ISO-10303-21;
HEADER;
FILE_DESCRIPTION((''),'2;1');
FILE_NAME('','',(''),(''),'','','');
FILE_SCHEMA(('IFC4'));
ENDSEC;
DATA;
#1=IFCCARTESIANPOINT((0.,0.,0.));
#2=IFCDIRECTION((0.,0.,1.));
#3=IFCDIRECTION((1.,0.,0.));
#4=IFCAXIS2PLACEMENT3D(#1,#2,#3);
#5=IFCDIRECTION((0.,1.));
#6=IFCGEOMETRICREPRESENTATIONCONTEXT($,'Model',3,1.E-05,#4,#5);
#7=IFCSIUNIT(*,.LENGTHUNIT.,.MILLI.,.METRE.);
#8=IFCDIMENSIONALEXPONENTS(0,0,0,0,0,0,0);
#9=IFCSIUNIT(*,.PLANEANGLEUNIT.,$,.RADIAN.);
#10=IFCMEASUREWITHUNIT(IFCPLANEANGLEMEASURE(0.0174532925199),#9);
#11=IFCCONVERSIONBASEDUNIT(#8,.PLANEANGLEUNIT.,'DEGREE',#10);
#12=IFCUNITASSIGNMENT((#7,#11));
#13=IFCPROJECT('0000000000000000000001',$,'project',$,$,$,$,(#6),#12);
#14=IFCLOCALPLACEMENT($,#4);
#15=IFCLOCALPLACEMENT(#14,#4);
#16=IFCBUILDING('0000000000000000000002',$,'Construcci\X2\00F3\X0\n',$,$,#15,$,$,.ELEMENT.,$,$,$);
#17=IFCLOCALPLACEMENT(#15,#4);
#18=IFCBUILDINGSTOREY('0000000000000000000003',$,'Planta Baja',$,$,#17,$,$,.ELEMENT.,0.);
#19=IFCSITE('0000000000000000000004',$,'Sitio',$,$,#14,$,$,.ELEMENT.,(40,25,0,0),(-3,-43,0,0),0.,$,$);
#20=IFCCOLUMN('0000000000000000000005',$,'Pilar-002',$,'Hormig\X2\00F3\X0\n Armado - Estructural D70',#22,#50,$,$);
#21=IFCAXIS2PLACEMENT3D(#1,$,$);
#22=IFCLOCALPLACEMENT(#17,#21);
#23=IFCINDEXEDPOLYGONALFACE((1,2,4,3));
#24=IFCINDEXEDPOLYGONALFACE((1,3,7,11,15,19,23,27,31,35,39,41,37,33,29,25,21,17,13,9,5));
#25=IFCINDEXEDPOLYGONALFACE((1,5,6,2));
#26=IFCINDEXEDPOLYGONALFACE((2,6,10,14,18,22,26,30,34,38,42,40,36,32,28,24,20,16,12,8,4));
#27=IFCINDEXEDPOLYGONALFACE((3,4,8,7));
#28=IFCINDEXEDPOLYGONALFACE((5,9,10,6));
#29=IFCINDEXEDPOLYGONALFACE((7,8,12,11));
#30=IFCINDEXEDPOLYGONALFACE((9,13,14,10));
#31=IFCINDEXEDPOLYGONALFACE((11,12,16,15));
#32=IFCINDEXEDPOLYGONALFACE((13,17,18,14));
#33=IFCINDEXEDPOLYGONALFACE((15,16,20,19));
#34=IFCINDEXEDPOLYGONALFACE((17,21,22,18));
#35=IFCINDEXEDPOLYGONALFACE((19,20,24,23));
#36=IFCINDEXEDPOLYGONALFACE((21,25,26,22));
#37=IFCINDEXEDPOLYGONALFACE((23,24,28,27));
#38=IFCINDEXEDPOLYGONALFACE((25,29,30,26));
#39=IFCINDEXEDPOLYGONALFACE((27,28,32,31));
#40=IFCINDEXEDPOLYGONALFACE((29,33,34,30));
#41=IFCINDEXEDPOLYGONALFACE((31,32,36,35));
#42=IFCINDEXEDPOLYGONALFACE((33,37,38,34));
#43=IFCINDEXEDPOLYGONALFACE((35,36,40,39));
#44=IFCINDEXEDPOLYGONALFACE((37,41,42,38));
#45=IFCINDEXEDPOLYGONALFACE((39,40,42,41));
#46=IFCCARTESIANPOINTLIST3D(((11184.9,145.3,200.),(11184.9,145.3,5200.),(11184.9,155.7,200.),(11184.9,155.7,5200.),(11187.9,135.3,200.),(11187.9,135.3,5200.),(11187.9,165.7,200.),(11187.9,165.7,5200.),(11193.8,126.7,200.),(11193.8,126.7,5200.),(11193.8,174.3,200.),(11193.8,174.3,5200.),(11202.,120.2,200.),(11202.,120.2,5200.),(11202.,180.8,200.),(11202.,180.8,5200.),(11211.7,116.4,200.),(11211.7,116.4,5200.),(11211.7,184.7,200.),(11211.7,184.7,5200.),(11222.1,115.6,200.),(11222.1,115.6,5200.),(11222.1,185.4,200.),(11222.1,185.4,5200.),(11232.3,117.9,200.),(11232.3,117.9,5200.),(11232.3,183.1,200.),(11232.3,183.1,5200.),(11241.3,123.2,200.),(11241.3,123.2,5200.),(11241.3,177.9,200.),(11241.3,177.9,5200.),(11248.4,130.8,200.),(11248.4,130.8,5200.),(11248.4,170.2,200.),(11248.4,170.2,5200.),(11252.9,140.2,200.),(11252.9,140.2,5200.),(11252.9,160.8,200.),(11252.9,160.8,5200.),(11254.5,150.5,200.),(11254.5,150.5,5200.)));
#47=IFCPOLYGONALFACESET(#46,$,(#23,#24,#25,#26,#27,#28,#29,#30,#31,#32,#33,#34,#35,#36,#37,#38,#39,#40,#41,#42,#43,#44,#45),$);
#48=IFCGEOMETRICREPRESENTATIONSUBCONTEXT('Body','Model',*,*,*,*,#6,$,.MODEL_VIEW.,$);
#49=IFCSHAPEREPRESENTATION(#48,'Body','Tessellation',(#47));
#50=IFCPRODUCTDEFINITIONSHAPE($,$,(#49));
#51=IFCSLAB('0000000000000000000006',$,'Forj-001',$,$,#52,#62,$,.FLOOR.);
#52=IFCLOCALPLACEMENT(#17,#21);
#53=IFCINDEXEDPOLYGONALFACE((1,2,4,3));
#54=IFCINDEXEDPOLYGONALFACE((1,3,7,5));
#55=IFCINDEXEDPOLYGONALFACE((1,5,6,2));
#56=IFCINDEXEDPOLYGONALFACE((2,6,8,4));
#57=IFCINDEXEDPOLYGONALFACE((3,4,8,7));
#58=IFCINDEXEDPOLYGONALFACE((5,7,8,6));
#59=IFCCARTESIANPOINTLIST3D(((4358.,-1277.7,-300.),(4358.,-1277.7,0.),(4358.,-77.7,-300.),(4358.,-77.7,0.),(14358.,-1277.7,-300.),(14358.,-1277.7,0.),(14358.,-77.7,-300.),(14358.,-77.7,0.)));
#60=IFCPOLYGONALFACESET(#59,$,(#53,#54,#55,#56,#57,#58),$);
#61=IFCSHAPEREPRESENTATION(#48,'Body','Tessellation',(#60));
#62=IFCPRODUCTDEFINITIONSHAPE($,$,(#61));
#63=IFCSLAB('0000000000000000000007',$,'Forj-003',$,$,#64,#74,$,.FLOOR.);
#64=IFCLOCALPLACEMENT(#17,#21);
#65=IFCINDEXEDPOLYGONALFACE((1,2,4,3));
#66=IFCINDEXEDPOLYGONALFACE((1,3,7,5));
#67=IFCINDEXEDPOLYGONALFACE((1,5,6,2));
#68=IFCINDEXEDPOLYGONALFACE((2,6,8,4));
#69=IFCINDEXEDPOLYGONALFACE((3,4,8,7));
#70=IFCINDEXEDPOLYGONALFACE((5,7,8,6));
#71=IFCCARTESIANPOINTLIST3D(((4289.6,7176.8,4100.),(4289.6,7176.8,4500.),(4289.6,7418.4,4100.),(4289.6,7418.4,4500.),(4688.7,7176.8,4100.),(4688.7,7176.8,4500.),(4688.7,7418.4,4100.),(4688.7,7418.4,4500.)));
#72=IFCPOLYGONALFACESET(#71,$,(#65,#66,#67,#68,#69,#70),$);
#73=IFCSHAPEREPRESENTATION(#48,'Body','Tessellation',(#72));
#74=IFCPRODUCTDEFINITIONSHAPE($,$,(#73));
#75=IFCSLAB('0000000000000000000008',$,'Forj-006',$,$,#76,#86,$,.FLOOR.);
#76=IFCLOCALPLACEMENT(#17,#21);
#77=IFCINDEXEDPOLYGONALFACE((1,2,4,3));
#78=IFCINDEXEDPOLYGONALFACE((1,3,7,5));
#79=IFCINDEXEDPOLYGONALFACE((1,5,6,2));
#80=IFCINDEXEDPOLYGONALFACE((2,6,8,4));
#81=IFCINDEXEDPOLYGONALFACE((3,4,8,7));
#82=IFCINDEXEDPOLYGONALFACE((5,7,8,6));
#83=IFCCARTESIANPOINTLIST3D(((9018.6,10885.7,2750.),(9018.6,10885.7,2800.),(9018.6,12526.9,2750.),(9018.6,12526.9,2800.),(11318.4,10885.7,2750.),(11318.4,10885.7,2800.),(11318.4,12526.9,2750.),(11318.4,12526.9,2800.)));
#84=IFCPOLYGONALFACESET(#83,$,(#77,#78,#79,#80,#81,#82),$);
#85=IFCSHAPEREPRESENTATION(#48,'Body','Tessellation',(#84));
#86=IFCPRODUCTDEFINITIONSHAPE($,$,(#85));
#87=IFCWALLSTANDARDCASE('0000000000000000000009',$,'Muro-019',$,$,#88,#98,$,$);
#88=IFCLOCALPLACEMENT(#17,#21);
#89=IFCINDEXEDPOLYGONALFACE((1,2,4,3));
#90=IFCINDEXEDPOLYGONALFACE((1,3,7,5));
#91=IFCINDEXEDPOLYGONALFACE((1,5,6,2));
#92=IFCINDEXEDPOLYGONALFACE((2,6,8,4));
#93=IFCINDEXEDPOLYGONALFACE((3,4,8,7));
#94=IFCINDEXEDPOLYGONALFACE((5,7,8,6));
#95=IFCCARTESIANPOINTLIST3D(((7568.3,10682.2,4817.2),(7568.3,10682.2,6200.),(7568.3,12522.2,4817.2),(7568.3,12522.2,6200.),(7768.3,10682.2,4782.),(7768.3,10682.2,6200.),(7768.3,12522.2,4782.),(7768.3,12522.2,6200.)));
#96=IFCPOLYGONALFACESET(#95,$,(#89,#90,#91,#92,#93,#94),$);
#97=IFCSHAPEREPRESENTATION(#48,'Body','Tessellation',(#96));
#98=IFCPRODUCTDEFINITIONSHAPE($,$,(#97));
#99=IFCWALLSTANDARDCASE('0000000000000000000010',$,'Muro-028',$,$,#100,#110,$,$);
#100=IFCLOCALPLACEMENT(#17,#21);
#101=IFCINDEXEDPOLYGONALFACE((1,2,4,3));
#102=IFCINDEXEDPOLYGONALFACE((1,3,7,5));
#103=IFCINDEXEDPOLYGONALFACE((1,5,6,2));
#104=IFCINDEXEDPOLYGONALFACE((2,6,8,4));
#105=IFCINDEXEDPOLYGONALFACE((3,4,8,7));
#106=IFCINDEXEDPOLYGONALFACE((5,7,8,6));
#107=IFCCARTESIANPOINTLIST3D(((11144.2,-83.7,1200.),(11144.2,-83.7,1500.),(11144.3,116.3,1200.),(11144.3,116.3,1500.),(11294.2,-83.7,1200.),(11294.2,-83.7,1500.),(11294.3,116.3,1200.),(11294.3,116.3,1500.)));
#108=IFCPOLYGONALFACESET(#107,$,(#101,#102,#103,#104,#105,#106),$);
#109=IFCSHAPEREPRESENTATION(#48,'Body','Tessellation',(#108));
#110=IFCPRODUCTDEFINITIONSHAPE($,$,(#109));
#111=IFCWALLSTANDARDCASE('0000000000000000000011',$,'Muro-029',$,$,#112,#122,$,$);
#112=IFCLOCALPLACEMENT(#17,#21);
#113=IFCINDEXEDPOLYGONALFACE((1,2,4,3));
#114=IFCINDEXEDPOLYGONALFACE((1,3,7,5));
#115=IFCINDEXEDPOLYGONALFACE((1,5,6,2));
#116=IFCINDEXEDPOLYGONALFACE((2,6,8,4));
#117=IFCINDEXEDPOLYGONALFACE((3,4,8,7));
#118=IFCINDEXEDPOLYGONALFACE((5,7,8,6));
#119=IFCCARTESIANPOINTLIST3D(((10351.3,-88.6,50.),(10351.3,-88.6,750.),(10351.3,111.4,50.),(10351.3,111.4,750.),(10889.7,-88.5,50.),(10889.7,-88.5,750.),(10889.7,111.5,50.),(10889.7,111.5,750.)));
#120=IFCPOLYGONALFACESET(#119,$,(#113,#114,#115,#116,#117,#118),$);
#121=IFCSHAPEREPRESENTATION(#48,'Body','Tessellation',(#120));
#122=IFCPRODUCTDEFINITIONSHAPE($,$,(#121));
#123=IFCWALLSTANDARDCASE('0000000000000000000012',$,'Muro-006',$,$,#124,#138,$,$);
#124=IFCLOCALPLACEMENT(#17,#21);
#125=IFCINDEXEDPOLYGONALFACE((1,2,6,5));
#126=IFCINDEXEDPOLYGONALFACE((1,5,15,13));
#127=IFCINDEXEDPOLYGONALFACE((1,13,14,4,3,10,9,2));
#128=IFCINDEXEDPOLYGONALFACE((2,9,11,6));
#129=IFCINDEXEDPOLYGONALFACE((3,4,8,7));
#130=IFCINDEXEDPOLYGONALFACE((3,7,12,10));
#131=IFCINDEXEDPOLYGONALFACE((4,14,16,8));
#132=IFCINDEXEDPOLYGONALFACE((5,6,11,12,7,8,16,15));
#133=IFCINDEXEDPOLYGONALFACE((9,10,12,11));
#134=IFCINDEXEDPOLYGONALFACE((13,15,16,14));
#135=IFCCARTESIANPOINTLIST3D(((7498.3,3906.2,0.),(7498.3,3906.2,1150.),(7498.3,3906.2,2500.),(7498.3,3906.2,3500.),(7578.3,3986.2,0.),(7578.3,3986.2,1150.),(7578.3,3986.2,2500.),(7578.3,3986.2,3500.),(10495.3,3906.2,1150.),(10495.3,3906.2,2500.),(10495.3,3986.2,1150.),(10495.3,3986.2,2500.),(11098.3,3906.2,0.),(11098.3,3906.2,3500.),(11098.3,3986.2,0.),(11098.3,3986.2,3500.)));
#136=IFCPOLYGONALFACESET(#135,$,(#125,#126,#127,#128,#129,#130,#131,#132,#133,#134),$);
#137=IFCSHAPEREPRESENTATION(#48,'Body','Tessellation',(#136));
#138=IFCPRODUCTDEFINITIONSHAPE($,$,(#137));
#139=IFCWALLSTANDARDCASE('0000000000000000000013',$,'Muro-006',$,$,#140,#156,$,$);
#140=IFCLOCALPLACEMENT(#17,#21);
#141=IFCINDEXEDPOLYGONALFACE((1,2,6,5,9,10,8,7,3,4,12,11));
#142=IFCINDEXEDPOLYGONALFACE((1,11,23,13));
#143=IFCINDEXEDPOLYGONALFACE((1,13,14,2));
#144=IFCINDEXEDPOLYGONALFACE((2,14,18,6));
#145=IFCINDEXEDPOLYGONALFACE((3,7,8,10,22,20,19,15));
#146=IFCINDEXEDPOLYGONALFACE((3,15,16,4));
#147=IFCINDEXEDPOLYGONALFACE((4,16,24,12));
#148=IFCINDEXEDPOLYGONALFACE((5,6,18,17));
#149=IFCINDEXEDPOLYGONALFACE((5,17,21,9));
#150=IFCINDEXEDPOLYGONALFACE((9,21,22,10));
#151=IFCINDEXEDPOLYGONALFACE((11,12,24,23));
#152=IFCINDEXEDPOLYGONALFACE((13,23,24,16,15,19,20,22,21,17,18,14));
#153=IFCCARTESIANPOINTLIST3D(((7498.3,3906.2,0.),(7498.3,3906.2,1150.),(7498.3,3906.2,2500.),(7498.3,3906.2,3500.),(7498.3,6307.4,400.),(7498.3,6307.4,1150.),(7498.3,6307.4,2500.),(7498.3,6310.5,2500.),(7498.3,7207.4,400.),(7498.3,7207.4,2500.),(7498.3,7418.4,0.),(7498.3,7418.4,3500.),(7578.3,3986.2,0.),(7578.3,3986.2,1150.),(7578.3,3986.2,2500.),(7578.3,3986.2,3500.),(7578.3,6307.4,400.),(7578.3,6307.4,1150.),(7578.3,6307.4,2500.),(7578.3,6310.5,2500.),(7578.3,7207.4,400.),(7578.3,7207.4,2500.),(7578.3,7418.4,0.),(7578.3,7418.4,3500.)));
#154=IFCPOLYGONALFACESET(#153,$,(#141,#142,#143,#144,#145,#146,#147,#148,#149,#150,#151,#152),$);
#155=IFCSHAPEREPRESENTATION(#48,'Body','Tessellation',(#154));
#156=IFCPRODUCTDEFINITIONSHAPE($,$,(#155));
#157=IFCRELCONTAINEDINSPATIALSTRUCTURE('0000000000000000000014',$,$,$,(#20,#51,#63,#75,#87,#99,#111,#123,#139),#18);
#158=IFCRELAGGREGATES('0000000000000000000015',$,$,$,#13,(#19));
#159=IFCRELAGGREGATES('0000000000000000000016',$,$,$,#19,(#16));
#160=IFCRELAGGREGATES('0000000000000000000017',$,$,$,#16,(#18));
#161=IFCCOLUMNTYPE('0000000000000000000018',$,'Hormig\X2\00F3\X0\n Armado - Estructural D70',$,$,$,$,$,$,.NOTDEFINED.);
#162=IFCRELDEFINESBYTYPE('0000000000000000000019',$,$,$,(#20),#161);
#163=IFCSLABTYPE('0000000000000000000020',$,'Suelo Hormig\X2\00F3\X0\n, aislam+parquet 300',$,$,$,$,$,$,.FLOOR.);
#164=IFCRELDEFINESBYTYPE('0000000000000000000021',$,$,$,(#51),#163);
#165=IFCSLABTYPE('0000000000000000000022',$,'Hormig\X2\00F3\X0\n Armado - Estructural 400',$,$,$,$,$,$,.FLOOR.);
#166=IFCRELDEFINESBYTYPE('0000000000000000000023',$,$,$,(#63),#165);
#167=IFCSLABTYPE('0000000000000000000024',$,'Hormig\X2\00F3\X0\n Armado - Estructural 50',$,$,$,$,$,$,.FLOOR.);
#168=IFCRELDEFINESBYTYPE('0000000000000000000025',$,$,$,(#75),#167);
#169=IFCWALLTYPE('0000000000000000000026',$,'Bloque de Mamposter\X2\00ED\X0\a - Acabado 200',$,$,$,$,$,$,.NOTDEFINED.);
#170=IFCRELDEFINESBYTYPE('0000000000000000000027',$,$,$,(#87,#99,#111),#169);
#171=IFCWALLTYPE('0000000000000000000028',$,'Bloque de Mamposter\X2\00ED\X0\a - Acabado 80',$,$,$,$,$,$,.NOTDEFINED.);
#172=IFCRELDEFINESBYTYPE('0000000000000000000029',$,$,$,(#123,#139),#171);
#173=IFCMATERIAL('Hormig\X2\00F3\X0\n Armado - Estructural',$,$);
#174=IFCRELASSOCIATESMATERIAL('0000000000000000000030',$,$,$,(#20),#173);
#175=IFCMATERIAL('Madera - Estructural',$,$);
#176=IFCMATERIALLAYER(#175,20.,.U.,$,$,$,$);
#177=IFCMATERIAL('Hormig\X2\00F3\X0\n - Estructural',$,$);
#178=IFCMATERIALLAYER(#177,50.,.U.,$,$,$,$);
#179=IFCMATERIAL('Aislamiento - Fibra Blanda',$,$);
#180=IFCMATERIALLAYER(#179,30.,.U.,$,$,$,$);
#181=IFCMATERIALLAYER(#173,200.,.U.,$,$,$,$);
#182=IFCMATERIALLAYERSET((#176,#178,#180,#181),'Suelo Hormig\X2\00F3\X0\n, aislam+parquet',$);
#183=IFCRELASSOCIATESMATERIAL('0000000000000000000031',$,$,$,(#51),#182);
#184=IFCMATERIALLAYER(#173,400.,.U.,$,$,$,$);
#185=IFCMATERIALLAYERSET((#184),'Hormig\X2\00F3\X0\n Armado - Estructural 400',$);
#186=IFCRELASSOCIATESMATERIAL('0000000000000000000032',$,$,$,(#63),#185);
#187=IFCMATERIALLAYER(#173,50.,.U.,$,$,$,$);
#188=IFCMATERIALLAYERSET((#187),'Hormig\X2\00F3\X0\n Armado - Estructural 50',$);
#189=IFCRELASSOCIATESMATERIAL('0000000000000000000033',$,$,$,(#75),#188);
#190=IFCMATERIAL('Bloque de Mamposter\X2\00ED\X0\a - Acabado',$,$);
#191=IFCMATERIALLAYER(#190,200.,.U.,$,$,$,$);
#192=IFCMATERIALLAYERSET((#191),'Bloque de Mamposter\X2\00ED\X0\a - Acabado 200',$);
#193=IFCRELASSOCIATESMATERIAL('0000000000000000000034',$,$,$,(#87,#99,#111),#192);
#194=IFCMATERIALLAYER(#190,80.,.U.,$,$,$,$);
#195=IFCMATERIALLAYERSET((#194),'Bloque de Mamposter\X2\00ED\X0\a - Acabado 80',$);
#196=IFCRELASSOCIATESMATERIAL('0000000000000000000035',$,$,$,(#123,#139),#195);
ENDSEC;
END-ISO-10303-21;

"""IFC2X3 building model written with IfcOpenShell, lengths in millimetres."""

from ifc_helpers import new_model, entity, si_unit, converted_unit, direction, frame, origin_with_axes, origin_2d_with_axis, place, context, subcontext, project, spatial, polyline, rectangle, circle, outline, extrude, clip, halfspace, material, layer, layer_set, layer_usage, type_object, element, save


model = new_model("IFC2X3")

# Units and contexts
model_context = context("Model", 3, precision=1e-05, world=origin_with_axes(), true_north=direction((0.0, 1.0)))
body_context = subcontext(model_context, "Body", "Model", "MODEL_VIEW")
ifc_project = project(units=[si_unit("LENGTHUNIT", "METRE", prefix="MILLI"), converted_unit("PLANEANGLEUNIT", "DEGREE", entity("IfcPlaneAngleMeasure", 0.0174532925199), si_unit("PLANEANGLEUNIT", "RADIAN"), dimensions=[0, 0, 0, 0, 0, 0, 0])], contexts=[model_context])

# Site, building, storey
site_placement = place(None, origin_with_axes())
site = spatial("IfcSite", under=ifc_project, at=site_placement, Name="Sitio", CompositionType="ELEMENT", RefLatitude=(40, 25, 0, 0), RefLongitude=(-3, -43, 0, 0), RefElevation=0.0)
building_placement = place(site_placement, origin_with_axes())
building = spatial("IfcBuilding", under=site, at=building_placement, Name="Construcción", CompositionType="ELEMENT")
storey_placement = place(building_placement, origin_with_axes())
storey = spatial("IfcBuildingStorey", under=building, at=storey_placement, Name="Planta Baja", CompositionType="ELEMENT", Elevation=0.0)

# Column
ifc_material_1 = material(Name="Hormigón Armado - Estructural")
column_type_1 = type_object("IfcColumnType", Name="Hormigón Armado - Estructural D70", PredefinedType="NOTDEFINED")
column_placement = place(storey_placement, frame((11219.5, 150.5, 200.0), z_axis=(0.0, 0.0, 1.0), x_axis=(1.0, 0.0, 0.0)))
element("IfcColumn", 1, at=column_placement, inside=storey, type_object=column_type_1, material=ifc_material_1, Name="Pilar-002", ObjectType="Hormigón Armado - Estructural D70", context=body_context, shape_type="SweptSolid", body=[
    extrude(circle(Radius=35.0, at=origin_2d_with_axis()), origin_with_axes(), (0.0, 0.0, 1.0), 5000.0),
])

# Slabs
ifc_material_2 = material(Name="Madera - Estructural")
ifc_layer_1 = layer(ifc_material_2, 20.0, ventilated="UNKNOWN")
ifc_material_3 = material(Name="Hormigón - Estructural")
ifc_layer_2 = layer(ifc_material_3, 50.0, ventilated="UNKNOWN")
ifc_material_4 = material(Name="Aislamiento - Fibra Blanda")
ifc_layer_3 = layer(ifc_material_4, 30.0, ventilated="UNKNOWN")
ifc_layer_4 = layer(ifc_material_1, 200.0, ventilated="UNKNOWN")
ifc_layer_set_1 = layer_set([ifc_layer_1, ifc_layer_2, ifc_layer_3, ifc_layer_4], Name="Suelo Hormigón, aislam+parquet")
ifc_layer_usage_1 = layer_usage(ifc_layer_set_1, "AXIS3", "NEGATIVE", 300.0)
slab_type_1 = type_object("IfcSlabType", Name="Suelo Hormigón, aislam+parquet 300", PredefinedType="FLOOR")
slab_1_placement = place(storey_placement, frame((4358.0, -77.7, 0.0), z_axis=(0.0, 0.0, 1.0), x_axis=(1.0, 0.0, 0.0)))
element("IfcSlab", 2, at=slab_1_placement, inside=storey, type_object=slab_type_1, material=ifc_layer_usage_1, Name="Forj-001", PredefinedType="FLOOR", context=body_context, shape_type="SweptSolid", body=[
    extrude(outline(polyline([(0.0, 0.0), (0.0, -1200.0), (10000.0, -1200.0), (10000.0, 0.0), (0.0, 0.0)])), frame((0.0, 0.0, -300.0), z_axis=(0.0, 0.0, 1.0), x_axis=(1.0, 0.0, 0.0)), (0.0, 0.0, 1.0), 300.0),
])
ifc_layer_5 = layer(ifc_material_1, 400.0, ventilated="UNKNOWN")
ifc_layer_set_2 = layer_set([ifc_layer_5], Name="Hormigón Armado - Estructural 400")
ifc_layer_usage_2 = layer_usage(ifc_layer_set_2, "AXIS3", "NEGATIVE", 400.0)
slab_type_2 = type_object("IfcSlabType", Name="Hormigón Armado - Estructural 400", PredefinedType="FLOOR")
slab_2_placement = place(storey_placement, frame((4289.6, 7176.8, 4500.0), z_axis=(0.0, 0.0, 1.0), x_axis=(1.0, 0.0, 0.0)))
element("IfcSlab", 3, at=slab_2_placement, inside=storey, type_object=slab_type_2, material=ifc_layer_usage_2, Name="Forj-003", PredefinedType="FLOOR", context=body_context, shape_type="SweptSolid", body=[
    extrude(outline(polyline([(0.0, 0.0), (399.0, 0.0), (399.0, 241.6), (0.0, 241.6), (0.0, 0.0)])), frame((0.0, 0.0, -400.0), z_axis=(0.0, 0.0, 1.0), x_axis=(1.0, 0.0, 0.0)), (0.0, 0.0, 1.0), 400.0),
])
ifc_layer_6 = layer(ifc_material_1, 50.0, ventilated="UNKNOWN")
ifc_layer_set_3 = layer_set([ifc_layer_6], Name="Hormigón Armado - Estructural 50")
ifc_layer_usage_3 = layer_usage(ifc_layer_set_3, "AXIS3", "NEGATIVE", 50.0)
slab_type_3 = type_object("IfcSlabType", Name="Hormigón Armado - Estructural 50", PredefinedType="FLOOR")
slab_3_placement = place(storey_placement, frame((9018.6, 10885.7, 2800.0), z_axis=(0.0, 0.0, 1.0), x_axis=(1.0, 0.0, 0.0)))
element("IfcSlab", 4, at=slab_3_placement, inside=storey, type_object=slab_type_3, material=ifc_layer_usage_3, Name="Forj-006", PredefinedType="FLOOR", context=body_context, shape_type="SweptSolid", body=[
    extrude(outline(polyline([(0.0, 0.0), (2299.8, 0.0), (2299.8, 1641.3), (0.0, 1641.2), (0.0, 0.0)])), frame((0.0, 0.0, -50.0), z_axis=(0.0, 0.0, 1.0), x_axis=(1.0, 0.0, 0.0)), (0.0, 0.0, 1.0), 50.0),
])

# Shared definitions
ifc_material_5 = material(Name="Bloque de Mampostería - Acabado")
ifc_layer_7 = layer(ifc_material_5, 200.0, ventilated="UNKNOWN")
ifc_layer_set_4 = layer_set([ifc_layer_7], Name="Bloque de Mampostería - Acabado 200")
wall_type_1 = type_object("IfcWallType", Name="Bloque de Mampostería - Acabado 200", PredefinedType="NOTDEFINED")

# Walls
ifc_layer_usage_4 = layer_usage(ifc_layer_set_4, "AXIS2", "POSITIVE", -200.0)
wall_1_placement = place(storey_placement, frame((7768.3, 12522.2, 3000.0), z_axis=(0.0, 0.0, 1.0), x_axis=(0.0, -1.0, 0.0)))
element("IfcWallStandardCase", 5, at=wall_1_placement, inside=storey, type_object=wall_type_1, material=ifc_layer_usage_4, Name="Muro-019", context=body_context, shape_type="Clipping", body=[
    clip(extrude(outline(polyline([(0.0, -200.0), (1840.0, -200.0), (1840.0, 0.0), (0.0, 0.0), (0.0, -200.0)])), origin_with_axes(), (0.0, 0.0, 1.0), 3200.0), halfspace(frame((0.0, 304.7, 1728.2), z_axis=(0.0, 0.173648, 0.984808), x_axis=(0.0, -0.984808, 0.173648)), True)),
])
ifc_layer_usage_5 = layer_usage(ifc_layer_set_4, "AXIS2", "POSITIVE", 0.0)
wall_2_placement = place(storey_placement, frame((11144.2, -83.7, 1200.0), z_axis=(0.0, 0.0, 1.0), x_axis=(1.0, -0.000082, 0.0)))
element("IfcWallStandardCase", 6, at=wall_2_placement, inside=storey, type_object=wall_type_1, material=ifc_layer_usage_5, Name="Muro-028", context=body_context, shape_type="SweptSolid", body=[
    extrude(outline(polyline([(0.0, 0.0), (150.0, 0.0), (150.0, 200.0), (0.0, 200.0), (0.0, 0.0)])), origin_with_axes(), (0.0, 0.0, 1.0), 300.0),
])
ifc_layer_usage_6 = layer_usage(ifc_layer_set_4, "AXIS2", "POSITIVE", 0.0)
wall_3_placement = place(storey_placement, frame((10351.3, -88.6, 50.0), z_axis=(0.0, 0.0, 1.0), x_axis=(1.0, 0.000068, 0.0)))
element("IfcWallStandardCase", 7, at=wall_3_placement, inside=storey, type_object=wall_type_1, material=ifc_layer_usage_6, Name="Muro-029", context=body_context, shape_type="SweptSolid", body=[
    extrude(outline(polyline([(0.0, 0.0), (538.4, 0.0), (538.4, 200.0), (0.0, 200.0), (0.0, 0.0)])), origin_with_axes(), (0.0, 0.0, 1.0), 700.0),
])

# Wall, opening
ifc_layer_8 = layer(ifc_material_5, 80.0, ventilated="UNKNOWN")
ifc_layer_set_5 = layer_set([ifc_layer_8], Name="Bloque de Mampostería - Acabado 80")
ifc_layer_usage_7 = layer_usage(ifc_layer_set_5, "AXIS2", "POSITIVE", 0.0)
wall_type_2 = type_object("IfcWallType", Name="Bloque de Mampostería - Acabado 80", PredefinedType="NOTDEFINED")
wall_4_placement = place(storey_placement, frame((7578.3, 3906.2, 0.0), z_axis=(0.0, 0.0, 1.0), x_axis=(1.0, 0.0, 0.0)))
wall_4 = element("IfcWallStandardCase", 8, at=wall_4_placement, inside=storey, type_object=wall_type_2, material=ifc_layer_usage_7, Name="Muro-006", context=body_context, shape_type="SweptSolid", body=[
    extrude(outline(polyline([(-80.0, 0.0), (3520.0, 0.0), (3520.0, 80.0), (0.0, 80.0), (-80.0, 0.0)])), origin_with_axes(), (0.0, 0.0, 1.0), 3500.0),
])
opening_1_placement = place(wall_4_placement, frame((1418.5, 0.0, 1150.0), z_axis=(0.0, 0.0, 1.0), x_axis=(1.0, 0.0, 0.0)))
element("IfcOpeningElement", 9, at=opening_1_placement, cuts=wall_4, context=body_context, shape_type="SweptSolid", body=[
    extrude(rectangle(XDim=2996.9, YDim=1350.0, at=origin_2d_with_axis()), frame((0.0, -80.0, 675.0), z_axis=(0.0, -1.0, 0.0), x_axis=(1.0, 0.0, 0.0)), (0.0, 0.0, -1.0), 240.0),
])

# Wall, openings
ifc_layer_usage_8 = layer_usage(ifc_layer_set_5, "AXIS2", "POSITIVE", 0.0)
wall_5_placement = place(storey_placement, frame((7578.3, 3906.2, 0.0), z_axis=(0.0, 0.0, 1.0), x_axis=(0.0, 1.0, 0.0)))
wall_5 = element("IfcWallStandardCase", 10, at=wall_5_placement, inside=storey, type_object=wall_type_2, material=ifc_layer_usage_8, Name="Muro-006", context=body_context, shape_type="SweptSolid", body=[
    extrude(outline(polyline([(80.0, 0.0), (3512.2, 0.0), (3512.2, 80.0), (0.0, 80.0), (80.0, 0.0)])), origin_with_axes(), (0.0, 0.0, 1.0), 3500.0),
])
opening_2_placement = place(wall_5_placement, frame((1202.2, 0.0, 1150.0), z_axis=(0.0, 0.0, 1.0), x_axis=(1.0, 0.0, 0.0)))
element("IfcOpeningElement", 11, at=opening_2_placement, cuts=wall_5, context=body_context, shape_type="SweptSolid", body=[
    extrude(rectangle(XDim=2404.4, YDim=1350.0, at=origin_2d_with_axis()), frame((0.0, -80.0, 675.0), z_axis=(0.0, -1.0, 0.0), x_axis=(1.0, 0.0, 0.0)), (0.0, 0.0, -1.0), 240.0),
])
opening_3_placement = place(wall_5_placement, frame((2851.2, 0.0, 400.0), z_axis=(0.0, 0.0, 1.0), x_axis=(1.0, 0.0, 0.0)))
element("IfcOpeningElement", 12, at=opening_3_placement, cuts=wall_5, context=body_context, shape_type="SweptSolid", body=[
    extrude(rectangle(XDim=900.0, YDim=2100.0, at=origin_2d_with_axis()), frame((0.0, -80.0, 1050.0), z_axis=(0.0, 1.0, 0.0), x_axis=(-1.0, 0.0, 0.0)), (0.0, 0.0, 1.0), 240.0),
])

save(model, "model.ifc")
